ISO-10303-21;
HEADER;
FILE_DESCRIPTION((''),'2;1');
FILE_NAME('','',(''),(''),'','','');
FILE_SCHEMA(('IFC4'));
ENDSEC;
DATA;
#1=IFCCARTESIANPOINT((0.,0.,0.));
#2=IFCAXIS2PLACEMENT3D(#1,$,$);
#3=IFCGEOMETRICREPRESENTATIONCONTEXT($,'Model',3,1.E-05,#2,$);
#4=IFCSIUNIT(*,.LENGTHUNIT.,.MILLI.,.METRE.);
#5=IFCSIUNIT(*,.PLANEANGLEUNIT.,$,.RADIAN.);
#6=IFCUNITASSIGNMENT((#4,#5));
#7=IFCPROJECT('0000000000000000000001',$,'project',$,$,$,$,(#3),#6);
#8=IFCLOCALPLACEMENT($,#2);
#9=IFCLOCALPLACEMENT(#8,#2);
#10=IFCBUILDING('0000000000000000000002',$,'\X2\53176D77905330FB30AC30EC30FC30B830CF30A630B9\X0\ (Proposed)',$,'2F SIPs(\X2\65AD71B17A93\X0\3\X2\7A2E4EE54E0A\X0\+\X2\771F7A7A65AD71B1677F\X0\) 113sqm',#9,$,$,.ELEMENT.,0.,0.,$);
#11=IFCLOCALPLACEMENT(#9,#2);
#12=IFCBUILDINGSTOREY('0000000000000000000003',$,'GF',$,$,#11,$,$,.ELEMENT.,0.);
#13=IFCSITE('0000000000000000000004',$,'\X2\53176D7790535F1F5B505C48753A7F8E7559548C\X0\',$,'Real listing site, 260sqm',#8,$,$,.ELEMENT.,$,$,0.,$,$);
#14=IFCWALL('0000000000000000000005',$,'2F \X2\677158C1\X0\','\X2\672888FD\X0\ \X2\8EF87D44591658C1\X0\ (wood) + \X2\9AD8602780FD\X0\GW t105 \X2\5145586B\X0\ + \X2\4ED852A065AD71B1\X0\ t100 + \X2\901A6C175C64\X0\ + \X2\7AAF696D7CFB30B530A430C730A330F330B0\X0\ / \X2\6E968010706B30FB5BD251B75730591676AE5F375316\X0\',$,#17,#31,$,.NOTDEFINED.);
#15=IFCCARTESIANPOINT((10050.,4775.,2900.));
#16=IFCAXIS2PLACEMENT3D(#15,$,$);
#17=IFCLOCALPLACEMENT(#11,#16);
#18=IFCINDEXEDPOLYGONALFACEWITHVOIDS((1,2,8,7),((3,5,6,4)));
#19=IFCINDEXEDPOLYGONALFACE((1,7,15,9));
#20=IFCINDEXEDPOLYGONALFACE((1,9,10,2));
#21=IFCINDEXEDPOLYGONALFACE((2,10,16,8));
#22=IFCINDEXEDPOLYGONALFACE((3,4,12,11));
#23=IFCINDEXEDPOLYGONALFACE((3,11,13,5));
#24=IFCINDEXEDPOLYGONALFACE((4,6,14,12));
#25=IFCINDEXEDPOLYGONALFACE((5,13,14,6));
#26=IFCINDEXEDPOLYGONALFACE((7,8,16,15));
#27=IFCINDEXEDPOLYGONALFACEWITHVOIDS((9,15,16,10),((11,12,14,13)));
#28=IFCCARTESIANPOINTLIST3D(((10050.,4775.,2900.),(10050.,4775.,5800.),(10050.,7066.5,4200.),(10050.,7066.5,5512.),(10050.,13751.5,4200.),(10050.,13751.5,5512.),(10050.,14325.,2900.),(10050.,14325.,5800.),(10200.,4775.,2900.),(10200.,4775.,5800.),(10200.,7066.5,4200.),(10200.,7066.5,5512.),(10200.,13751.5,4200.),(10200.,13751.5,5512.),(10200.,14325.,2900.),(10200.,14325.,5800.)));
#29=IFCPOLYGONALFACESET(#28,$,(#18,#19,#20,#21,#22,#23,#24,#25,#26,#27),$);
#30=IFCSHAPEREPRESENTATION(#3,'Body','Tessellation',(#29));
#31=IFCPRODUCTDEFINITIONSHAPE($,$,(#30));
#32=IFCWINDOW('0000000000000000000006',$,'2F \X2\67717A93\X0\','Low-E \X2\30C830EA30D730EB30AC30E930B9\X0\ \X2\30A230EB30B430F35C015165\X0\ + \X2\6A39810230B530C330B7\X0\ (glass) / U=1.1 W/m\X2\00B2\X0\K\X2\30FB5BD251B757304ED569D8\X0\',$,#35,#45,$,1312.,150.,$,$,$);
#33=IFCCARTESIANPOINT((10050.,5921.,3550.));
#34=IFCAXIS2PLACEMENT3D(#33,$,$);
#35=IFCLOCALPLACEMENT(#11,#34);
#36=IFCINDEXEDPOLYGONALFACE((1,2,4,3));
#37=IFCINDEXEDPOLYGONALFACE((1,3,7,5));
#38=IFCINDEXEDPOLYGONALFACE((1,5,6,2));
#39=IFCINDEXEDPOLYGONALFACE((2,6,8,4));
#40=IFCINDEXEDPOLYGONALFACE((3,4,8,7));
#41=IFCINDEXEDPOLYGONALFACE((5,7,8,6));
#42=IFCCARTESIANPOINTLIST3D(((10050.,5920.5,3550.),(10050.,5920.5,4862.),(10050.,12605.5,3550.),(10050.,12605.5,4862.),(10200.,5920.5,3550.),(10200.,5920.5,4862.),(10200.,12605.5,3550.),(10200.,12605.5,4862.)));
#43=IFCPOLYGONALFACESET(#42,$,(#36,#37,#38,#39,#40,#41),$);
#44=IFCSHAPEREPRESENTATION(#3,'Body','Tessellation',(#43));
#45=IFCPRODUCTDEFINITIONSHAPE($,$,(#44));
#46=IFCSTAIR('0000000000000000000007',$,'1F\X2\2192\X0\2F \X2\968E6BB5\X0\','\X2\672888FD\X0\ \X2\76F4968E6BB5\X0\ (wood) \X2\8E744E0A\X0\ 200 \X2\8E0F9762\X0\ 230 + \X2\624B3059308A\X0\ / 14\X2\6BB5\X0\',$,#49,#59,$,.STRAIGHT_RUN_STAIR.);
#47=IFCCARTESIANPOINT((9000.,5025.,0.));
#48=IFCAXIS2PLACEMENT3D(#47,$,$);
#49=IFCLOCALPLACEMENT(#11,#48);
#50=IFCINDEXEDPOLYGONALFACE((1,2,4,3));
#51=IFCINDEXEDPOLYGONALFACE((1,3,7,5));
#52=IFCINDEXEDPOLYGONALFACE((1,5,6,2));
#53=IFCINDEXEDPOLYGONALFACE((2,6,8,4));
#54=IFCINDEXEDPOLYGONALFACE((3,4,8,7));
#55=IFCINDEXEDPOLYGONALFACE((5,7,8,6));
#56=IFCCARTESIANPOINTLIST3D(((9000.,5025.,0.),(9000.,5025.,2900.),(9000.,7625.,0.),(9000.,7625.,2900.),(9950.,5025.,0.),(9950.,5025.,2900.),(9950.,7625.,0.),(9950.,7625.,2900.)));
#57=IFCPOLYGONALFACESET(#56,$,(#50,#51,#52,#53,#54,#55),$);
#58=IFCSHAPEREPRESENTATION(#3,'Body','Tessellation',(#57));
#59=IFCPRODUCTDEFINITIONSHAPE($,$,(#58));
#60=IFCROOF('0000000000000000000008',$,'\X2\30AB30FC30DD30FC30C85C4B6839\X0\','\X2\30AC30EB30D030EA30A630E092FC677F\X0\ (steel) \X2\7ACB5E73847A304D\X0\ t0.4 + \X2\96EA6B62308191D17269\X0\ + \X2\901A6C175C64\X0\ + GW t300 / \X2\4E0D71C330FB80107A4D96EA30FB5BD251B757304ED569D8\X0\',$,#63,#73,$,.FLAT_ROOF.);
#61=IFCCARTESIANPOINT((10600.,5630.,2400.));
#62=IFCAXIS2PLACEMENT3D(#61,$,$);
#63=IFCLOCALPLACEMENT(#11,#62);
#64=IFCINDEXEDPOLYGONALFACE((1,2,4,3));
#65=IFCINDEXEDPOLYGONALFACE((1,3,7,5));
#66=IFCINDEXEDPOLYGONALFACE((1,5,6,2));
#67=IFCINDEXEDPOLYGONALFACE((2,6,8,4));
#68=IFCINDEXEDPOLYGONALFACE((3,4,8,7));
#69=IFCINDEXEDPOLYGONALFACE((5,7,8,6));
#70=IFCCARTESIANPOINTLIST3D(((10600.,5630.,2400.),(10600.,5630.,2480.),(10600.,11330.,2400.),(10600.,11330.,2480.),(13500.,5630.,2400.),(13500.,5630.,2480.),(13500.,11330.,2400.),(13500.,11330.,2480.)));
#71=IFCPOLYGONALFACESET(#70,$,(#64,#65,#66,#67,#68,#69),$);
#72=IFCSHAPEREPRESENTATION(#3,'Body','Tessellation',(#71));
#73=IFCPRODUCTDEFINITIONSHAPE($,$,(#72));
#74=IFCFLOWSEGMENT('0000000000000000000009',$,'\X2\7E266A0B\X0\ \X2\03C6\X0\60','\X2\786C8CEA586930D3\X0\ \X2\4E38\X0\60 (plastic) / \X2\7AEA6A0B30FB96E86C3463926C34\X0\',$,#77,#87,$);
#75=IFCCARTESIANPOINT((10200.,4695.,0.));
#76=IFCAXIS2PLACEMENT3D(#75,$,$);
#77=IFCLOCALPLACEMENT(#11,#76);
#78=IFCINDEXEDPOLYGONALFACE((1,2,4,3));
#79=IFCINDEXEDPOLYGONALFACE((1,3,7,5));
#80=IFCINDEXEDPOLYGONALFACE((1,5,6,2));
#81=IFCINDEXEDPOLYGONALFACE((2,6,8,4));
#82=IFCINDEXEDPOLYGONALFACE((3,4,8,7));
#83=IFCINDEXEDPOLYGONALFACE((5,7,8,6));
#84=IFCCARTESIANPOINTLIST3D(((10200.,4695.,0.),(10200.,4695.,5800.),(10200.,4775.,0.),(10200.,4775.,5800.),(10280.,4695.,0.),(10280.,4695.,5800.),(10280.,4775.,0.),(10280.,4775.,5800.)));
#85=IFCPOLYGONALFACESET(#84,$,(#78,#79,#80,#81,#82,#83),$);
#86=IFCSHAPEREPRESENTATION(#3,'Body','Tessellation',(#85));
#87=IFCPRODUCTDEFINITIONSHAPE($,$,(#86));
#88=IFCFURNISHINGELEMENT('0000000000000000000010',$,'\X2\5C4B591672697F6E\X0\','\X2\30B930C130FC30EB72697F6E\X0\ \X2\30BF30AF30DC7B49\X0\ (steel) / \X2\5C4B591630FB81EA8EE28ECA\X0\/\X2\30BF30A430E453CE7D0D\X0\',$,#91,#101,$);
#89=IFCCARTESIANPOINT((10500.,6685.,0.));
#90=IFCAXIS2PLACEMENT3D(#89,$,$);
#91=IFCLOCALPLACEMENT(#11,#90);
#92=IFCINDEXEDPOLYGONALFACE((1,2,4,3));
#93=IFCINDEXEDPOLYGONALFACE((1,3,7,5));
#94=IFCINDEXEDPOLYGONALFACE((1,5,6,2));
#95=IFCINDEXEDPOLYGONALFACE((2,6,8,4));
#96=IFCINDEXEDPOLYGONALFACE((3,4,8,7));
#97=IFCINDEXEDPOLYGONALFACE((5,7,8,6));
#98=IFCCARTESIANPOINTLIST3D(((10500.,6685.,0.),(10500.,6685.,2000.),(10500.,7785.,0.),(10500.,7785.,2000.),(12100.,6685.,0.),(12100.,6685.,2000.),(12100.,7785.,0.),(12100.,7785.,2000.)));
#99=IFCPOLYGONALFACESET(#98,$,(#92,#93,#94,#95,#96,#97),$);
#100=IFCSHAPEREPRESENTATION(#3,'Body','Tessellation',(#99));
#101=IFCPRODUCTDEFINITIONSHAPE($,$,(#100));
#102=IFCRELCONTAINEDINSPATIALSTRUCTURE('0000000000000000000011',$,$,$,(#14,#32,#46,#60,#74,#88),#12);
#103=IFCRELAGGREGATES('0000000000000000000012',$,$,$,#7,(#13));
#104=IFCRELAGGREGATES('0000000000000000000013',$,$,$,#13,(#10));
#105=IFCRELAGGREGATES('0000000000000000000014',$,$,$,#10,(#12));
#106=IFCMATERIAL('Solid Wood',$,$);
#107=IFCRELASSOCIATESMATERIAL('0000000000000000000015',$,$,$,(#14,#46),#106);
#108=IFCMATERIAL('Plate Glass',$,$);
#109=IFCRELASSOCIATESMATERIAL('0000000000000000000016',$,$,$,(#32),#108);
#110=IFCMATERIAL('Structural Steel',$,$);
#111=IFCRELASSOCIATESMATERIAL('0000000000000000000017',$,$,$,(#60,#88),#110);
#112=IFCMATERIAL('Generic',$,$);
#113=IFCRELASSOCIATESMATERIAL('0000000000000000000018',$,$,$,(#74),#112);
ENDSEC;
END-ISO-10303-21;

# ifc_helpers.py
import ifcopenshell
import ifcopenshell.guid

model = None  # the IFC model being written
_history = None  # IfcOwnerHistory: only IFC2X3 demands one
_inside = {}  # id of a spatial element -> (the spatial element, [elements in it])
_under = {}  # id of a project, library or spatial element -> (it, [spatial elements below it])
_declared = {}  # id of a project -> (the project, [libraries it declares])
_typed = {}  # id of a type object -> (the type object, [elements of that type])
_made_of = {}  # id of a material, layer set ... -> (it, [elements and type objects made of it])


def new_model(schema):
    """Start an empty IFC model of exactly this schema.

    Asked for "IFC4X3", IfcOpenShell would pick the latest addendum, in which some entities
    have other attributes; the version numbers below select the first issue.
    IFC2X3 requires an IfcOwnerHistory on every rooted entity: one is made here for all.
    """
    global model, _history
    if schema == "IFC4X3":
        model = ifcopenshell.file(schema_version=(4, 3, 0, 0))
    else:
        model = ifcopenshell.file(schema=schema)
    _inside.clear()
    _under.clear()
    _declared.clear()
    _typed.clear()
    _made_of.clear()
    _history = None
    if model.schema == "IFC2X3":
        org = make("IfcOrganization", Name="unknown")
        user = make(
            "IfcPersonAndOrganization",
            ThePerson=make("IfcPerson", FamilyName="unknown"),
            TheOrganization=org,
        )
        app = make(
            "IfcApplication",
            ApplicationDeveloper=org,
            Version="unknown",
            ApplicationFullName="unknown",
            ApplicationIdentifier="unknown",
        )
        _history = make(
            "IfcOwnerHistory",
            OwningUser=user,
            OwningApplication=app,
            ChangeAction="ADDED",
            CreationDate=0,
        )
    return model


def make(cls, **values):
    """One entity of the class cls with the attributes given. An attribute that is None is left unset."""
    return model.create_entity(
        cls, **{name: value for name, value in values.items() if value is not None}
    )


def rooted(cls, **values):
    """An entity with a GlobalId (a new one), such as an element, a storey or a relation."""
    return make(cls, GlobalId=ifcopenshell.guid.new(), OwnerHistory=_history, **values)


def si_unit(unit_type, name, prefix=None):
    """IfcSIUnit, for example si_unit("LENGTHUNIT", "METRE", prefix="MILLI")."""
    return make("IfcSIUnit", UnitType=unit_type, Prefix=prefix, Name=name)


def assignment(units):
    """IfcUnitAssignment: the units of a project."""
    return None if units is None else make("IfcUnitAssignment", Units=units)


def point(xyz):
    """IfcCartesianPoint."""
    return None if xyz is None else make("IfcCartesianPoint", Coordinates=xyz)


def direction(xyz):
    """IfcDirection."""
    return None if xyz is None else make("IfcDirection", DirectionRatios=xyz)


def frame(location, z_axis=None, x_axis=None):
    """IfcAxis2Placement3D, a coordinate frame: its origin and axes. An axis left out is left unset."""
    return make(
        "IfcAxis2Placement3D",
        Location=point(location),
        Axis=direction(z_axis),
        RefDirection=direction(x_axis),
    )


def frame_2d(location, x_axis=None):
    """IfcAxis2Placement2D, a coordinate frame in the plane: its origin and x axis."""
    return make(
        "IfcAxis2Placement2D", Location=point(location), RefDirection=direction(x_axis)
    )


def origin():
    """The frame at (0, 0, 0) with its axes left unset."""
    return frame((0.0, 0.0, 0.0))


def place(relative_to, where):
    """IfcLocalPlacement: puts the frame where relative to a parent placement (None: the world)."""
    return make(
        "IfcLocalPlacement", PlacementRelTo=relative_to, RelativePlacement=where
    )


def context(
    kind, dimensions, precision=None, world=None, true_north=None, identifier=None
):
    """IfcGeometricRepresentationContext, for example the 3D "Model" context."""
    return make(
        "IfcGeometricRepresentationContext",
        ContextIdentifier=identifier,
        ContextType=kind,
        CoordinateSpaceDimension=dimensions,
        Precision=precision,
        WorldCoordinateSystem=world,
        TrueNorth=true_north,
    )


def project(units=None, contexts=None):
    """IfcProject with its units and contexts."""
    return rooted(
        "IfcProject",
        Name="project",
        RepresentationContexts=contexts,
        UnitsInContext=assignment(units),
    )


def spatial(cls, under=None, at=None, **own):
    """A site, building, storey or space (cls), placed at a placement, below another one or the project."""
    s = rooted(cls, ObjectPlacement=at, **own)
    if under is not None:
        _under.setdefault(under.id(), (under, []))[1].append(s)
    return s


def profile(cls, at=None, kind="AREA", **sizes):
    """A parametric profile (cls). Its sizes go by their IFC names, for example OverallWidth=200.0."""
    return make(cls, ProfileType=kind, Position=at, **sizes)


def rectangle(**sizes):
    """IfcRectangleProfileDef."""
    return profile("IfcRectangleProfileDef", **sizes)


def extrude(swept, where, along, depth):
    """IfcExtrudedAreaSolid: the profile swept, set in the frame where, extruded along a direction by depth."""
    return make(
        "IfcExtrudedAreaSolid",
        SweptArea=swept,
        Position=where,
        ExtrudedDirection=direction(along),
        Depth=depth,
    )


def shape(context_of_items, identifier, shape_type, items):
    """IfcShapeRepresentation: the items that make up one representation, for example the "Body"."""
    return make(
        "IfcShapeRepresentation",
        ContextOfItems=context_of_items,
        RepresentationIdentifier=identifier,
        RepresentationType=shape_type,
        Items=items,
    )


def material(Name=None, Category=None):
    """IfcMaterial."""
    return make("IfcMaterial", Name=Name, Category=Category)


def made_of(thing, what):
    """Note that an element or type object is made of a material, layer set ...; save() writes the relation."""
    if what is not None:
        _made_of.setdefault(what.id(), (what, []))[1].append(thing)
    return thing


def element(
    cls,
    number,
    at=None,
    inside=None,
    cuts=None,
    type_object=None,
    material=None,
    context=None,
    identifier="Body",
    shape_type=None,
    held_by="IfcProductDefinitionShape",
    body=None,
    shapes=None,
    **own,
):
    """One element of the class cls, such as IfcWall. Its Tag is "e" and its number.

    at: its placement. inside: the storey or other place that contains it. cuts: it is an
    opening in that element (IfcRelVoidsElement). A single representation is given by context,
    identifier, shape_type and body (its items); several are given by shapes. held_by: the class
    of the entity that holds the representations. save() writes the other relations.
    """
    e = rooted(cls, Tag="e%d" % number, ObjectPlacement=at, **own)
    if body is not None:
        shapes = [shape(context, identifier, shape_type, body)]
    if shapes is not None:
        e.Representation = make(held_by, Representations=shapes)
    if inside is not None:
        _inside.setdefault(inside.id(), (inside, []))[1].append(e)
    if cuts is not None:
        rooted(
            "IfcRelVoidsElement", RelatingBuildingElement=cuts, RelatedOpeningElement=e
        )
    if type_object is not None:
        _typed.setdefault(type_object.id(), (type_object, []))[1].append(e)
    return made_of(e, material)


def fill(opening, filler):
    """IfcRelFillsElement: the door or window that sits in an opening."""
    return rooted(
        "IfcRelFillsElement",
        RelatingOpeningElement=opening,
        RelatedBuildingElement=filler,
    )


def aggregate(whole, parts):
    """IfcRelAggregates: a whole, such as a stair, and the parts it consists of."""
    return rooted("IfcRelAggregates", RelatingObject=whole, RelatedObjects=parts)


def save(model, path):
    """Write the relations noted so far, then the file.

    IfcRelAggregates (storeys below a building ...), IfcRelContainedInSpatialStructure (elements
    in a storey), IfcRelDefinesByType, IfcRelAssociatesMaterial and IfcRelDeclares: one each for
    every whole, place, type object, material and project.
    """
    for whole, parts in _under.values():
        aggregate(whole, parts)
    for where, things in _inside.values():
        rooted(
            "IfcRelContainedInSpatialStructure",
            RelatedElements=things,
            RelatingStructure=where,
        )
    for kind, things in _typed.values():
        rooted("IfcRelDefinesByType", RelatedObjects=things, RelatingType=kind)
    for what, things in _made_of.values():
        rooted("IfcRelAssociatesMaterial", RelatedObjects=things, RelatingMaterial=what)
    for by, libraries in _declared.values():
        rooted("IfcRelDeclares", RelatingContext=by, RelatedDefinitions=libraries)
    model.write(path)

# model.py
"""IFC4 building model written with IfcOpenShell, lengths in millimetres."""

from ifc_helpers import new_model, si_unit, frame, frame_2d, origin, place, context, project, spatial, rectangle, extrude, material, element, fill, save


model = new_model("IFC4")

# Units and contexts
model_context = context("Model", 3, precision=1e-05, world=origin())
ifc_project = project(units=[si_unit("LENGTHUNIT", "METRE", prefix="MILLI"), si_unit("PLANEANGLEUNIT", "RADIAN")], contexts=[model_context])

# Site, building, storey
site_placement = place(None, origin())
site = spatial("IfcSite", under=ifc_project, at=site_placement, Name="北海道弟子屈町美留和", ObjectType="Real listing site, 260sqm", CompositionType="ELEMENT", RefElevation=0.0)
building_placement = place(site_placement, origin())
building = spatial("IfcBuilding", under=site, at=building_placement, Name="北海道・ガレージハウス (Proposed)", ObjectType="2F SIPs(断熱窓3種以上+真空断熱板) 113sqm", CompositionType="ELEMENT", ElevationOfRefHeight=0.0, ElevationOfTerrain=0.0)
storey_placement = place(building_placement, origin())
storey = spatial("IfcBuildingStorey", under=building, at=storey_placement, Name="GF", CompositionType="ELEMENT", Elevation=0.0)

# Shared definitions
ifc_material_1 = material(Name="Solid Wood")
ifc_material_2 = material(Name="Structural Steel")

# Wall, opening, window
ifc_material_3 = material(Name="Plate Glass")
wall_1_placement = place(storey_placement, frame((10050.0, 4775.0, 2900.0)))
wall_1 = element("IfcWall", 1, at=wall_1_placement, inside=storey, material=ifc_material_1, Name="2F 東壁", Description="木製 軸組外壁 (wood) + 高性能GW t105 充填 + 付加断熱 t100 + 通気層 + 窯業系サイディング / 準耐火・寒冷地外皮強化", PredefinedType="NOTDEFINED", context=model_context, shape_type="SweptSolid", body=[
    extrude(rectangle(XDim=150.0, YDim=9550.0, at=frame_2d((75.0, 4775.0))), frame((10050.0, 4775.0, 2900.0)), (0.0, 0.0, 1.0), 2900.0),
])
opening_1_placement = place(storey_placement, frame((10050.0, 5921.0, 3550.0)))
opening_1 = element("IfcOpeningElement", 2, at=opening_1_placement, cuts=wall_1, PredefinedType="NOTDEFINED", context=model_context, shape_type="SweptSolid", body=[
    extrude(rectangle(XDim=150.0, YDim=6685.0, at=frame_2d((75.0, 3342.0))), frame((10050.0, 5921.0, 3550.0)), (0.0, 0.0, 1.0), 1312.0),
])
window_1_placement = place(storey_placement, frame((10050.0, 5921.0, 3550.0)))
window_1 = element("IfcWindow", 3, at=window_1_placement, inside=storey, material=ifc_material_3, Name="2F 東窓", Description="Low-E トリプルガラス アルゴン封入 + 樹脂サッシ (glass) / U=1.1 W/m²K・寒冷地仕様", OverallHeight=1312.0, OverallWidth=150.0, context=model_context, shape_type="SweptSolid", body=[
    extrude(rectangle(XDim=150.0, YDim=6685.0, at=frame_2d((75.0, 3342.0))), frame((10050.0, 5921.0, 3550.0)), (0.0, 0.0, 1.0), 1312.0),
])
fill(opening_1, window_1)

# Stair
stair_placement = place(storey_placement, frame((9000.0, 5025.0, 0.0)))
element("IfcStair", 4, at=stair_placement, inside=storey, material=ifc_material_1, Name="1F→2F 階段", Description="木製 直階段 (wood) 蹴上 200 踏面 230 + 手すり / 14段", PredefinedType="STRAIGHT_RUN_STAIR", context=model_context, shape_type="SweptSolid", body=[
    extrude(rectangle(XDim=950.0, YDim=2600.0, at=frame_2d((475.0, 1300.0))), frame((9000.0, 5025.0, 0.0)), (0.0, 0.0, 1.0), 2900.0),
])

# Roof
roof_placement = place(storey_placement, frame((10600.0, 5630.0, 2400.0)))
element("IfcRoof", 5, at=roof_placement, inside=storey, material=ifc_material_2, Name="カーポート屋根", Description="ガルバリウム鋼板 (steel) 立平葺き t0.4 + 雪止め金物 + 通気層 + GW t300 / 不燃・耐積雪・寒冷地仕様", PredefinedType="FLAT_ROOF", context=model_context, shape_type="SweptSolid", body=[
    extrude(rectangle(XDim=2900.0, YDim=5700.0, at=frame_2d((1450.0, 2850.0))), frame((10600.0, 5630.0, 2400.0)), (0.0, 0.0, 1.0), 80.0),
])

# Flow segment
ifc_material_4 = material(Name="Generic")
flow_segment_placement = place(storey_placement, frame((10200.0, 4695.0, 0.0)))
element("IfcFlowSegment", 6, at=flow_segment_placement, inside=storey, material=ifc_material_4, Name="縦樋 φ60", Description="硬質塩ビ 丸60 (plastic) / 竪樋・雨水排水", context=model_context, shape_type="SweptSolid", body=[
    extrude(rectangle(XDim=80.0, YDim=80.0, at=frame_2d((40.0, 40.0))), frame((10200.0, 4695.0, 0.0)), (0.0, 0.0, 1.0), 5800.0),
])

# Furnishing element
furnishing_placement = place(storey_placement, frame((10500.0, 6685.0, 0.0)))
element("IfcFurnishingElement", 7, at=furnishing_placement, inside=storey, material=ifc_material_2, Name="屋外物置", Description="スチール物置 タクボ等 (steel) / 屋外・自転車/タイヤ収納", context=model_context, shape_type="SweptSolid", body=[
    extrude(rectangle(XDim=1600.0, YDim=1100.0, at=frame_2d((800.0, 550.0))), frame((10500.0, 6685.0, 0.0)), (0.0, 0.0, 1.0), 2000.0),
])

save(model, "model.ifc")
